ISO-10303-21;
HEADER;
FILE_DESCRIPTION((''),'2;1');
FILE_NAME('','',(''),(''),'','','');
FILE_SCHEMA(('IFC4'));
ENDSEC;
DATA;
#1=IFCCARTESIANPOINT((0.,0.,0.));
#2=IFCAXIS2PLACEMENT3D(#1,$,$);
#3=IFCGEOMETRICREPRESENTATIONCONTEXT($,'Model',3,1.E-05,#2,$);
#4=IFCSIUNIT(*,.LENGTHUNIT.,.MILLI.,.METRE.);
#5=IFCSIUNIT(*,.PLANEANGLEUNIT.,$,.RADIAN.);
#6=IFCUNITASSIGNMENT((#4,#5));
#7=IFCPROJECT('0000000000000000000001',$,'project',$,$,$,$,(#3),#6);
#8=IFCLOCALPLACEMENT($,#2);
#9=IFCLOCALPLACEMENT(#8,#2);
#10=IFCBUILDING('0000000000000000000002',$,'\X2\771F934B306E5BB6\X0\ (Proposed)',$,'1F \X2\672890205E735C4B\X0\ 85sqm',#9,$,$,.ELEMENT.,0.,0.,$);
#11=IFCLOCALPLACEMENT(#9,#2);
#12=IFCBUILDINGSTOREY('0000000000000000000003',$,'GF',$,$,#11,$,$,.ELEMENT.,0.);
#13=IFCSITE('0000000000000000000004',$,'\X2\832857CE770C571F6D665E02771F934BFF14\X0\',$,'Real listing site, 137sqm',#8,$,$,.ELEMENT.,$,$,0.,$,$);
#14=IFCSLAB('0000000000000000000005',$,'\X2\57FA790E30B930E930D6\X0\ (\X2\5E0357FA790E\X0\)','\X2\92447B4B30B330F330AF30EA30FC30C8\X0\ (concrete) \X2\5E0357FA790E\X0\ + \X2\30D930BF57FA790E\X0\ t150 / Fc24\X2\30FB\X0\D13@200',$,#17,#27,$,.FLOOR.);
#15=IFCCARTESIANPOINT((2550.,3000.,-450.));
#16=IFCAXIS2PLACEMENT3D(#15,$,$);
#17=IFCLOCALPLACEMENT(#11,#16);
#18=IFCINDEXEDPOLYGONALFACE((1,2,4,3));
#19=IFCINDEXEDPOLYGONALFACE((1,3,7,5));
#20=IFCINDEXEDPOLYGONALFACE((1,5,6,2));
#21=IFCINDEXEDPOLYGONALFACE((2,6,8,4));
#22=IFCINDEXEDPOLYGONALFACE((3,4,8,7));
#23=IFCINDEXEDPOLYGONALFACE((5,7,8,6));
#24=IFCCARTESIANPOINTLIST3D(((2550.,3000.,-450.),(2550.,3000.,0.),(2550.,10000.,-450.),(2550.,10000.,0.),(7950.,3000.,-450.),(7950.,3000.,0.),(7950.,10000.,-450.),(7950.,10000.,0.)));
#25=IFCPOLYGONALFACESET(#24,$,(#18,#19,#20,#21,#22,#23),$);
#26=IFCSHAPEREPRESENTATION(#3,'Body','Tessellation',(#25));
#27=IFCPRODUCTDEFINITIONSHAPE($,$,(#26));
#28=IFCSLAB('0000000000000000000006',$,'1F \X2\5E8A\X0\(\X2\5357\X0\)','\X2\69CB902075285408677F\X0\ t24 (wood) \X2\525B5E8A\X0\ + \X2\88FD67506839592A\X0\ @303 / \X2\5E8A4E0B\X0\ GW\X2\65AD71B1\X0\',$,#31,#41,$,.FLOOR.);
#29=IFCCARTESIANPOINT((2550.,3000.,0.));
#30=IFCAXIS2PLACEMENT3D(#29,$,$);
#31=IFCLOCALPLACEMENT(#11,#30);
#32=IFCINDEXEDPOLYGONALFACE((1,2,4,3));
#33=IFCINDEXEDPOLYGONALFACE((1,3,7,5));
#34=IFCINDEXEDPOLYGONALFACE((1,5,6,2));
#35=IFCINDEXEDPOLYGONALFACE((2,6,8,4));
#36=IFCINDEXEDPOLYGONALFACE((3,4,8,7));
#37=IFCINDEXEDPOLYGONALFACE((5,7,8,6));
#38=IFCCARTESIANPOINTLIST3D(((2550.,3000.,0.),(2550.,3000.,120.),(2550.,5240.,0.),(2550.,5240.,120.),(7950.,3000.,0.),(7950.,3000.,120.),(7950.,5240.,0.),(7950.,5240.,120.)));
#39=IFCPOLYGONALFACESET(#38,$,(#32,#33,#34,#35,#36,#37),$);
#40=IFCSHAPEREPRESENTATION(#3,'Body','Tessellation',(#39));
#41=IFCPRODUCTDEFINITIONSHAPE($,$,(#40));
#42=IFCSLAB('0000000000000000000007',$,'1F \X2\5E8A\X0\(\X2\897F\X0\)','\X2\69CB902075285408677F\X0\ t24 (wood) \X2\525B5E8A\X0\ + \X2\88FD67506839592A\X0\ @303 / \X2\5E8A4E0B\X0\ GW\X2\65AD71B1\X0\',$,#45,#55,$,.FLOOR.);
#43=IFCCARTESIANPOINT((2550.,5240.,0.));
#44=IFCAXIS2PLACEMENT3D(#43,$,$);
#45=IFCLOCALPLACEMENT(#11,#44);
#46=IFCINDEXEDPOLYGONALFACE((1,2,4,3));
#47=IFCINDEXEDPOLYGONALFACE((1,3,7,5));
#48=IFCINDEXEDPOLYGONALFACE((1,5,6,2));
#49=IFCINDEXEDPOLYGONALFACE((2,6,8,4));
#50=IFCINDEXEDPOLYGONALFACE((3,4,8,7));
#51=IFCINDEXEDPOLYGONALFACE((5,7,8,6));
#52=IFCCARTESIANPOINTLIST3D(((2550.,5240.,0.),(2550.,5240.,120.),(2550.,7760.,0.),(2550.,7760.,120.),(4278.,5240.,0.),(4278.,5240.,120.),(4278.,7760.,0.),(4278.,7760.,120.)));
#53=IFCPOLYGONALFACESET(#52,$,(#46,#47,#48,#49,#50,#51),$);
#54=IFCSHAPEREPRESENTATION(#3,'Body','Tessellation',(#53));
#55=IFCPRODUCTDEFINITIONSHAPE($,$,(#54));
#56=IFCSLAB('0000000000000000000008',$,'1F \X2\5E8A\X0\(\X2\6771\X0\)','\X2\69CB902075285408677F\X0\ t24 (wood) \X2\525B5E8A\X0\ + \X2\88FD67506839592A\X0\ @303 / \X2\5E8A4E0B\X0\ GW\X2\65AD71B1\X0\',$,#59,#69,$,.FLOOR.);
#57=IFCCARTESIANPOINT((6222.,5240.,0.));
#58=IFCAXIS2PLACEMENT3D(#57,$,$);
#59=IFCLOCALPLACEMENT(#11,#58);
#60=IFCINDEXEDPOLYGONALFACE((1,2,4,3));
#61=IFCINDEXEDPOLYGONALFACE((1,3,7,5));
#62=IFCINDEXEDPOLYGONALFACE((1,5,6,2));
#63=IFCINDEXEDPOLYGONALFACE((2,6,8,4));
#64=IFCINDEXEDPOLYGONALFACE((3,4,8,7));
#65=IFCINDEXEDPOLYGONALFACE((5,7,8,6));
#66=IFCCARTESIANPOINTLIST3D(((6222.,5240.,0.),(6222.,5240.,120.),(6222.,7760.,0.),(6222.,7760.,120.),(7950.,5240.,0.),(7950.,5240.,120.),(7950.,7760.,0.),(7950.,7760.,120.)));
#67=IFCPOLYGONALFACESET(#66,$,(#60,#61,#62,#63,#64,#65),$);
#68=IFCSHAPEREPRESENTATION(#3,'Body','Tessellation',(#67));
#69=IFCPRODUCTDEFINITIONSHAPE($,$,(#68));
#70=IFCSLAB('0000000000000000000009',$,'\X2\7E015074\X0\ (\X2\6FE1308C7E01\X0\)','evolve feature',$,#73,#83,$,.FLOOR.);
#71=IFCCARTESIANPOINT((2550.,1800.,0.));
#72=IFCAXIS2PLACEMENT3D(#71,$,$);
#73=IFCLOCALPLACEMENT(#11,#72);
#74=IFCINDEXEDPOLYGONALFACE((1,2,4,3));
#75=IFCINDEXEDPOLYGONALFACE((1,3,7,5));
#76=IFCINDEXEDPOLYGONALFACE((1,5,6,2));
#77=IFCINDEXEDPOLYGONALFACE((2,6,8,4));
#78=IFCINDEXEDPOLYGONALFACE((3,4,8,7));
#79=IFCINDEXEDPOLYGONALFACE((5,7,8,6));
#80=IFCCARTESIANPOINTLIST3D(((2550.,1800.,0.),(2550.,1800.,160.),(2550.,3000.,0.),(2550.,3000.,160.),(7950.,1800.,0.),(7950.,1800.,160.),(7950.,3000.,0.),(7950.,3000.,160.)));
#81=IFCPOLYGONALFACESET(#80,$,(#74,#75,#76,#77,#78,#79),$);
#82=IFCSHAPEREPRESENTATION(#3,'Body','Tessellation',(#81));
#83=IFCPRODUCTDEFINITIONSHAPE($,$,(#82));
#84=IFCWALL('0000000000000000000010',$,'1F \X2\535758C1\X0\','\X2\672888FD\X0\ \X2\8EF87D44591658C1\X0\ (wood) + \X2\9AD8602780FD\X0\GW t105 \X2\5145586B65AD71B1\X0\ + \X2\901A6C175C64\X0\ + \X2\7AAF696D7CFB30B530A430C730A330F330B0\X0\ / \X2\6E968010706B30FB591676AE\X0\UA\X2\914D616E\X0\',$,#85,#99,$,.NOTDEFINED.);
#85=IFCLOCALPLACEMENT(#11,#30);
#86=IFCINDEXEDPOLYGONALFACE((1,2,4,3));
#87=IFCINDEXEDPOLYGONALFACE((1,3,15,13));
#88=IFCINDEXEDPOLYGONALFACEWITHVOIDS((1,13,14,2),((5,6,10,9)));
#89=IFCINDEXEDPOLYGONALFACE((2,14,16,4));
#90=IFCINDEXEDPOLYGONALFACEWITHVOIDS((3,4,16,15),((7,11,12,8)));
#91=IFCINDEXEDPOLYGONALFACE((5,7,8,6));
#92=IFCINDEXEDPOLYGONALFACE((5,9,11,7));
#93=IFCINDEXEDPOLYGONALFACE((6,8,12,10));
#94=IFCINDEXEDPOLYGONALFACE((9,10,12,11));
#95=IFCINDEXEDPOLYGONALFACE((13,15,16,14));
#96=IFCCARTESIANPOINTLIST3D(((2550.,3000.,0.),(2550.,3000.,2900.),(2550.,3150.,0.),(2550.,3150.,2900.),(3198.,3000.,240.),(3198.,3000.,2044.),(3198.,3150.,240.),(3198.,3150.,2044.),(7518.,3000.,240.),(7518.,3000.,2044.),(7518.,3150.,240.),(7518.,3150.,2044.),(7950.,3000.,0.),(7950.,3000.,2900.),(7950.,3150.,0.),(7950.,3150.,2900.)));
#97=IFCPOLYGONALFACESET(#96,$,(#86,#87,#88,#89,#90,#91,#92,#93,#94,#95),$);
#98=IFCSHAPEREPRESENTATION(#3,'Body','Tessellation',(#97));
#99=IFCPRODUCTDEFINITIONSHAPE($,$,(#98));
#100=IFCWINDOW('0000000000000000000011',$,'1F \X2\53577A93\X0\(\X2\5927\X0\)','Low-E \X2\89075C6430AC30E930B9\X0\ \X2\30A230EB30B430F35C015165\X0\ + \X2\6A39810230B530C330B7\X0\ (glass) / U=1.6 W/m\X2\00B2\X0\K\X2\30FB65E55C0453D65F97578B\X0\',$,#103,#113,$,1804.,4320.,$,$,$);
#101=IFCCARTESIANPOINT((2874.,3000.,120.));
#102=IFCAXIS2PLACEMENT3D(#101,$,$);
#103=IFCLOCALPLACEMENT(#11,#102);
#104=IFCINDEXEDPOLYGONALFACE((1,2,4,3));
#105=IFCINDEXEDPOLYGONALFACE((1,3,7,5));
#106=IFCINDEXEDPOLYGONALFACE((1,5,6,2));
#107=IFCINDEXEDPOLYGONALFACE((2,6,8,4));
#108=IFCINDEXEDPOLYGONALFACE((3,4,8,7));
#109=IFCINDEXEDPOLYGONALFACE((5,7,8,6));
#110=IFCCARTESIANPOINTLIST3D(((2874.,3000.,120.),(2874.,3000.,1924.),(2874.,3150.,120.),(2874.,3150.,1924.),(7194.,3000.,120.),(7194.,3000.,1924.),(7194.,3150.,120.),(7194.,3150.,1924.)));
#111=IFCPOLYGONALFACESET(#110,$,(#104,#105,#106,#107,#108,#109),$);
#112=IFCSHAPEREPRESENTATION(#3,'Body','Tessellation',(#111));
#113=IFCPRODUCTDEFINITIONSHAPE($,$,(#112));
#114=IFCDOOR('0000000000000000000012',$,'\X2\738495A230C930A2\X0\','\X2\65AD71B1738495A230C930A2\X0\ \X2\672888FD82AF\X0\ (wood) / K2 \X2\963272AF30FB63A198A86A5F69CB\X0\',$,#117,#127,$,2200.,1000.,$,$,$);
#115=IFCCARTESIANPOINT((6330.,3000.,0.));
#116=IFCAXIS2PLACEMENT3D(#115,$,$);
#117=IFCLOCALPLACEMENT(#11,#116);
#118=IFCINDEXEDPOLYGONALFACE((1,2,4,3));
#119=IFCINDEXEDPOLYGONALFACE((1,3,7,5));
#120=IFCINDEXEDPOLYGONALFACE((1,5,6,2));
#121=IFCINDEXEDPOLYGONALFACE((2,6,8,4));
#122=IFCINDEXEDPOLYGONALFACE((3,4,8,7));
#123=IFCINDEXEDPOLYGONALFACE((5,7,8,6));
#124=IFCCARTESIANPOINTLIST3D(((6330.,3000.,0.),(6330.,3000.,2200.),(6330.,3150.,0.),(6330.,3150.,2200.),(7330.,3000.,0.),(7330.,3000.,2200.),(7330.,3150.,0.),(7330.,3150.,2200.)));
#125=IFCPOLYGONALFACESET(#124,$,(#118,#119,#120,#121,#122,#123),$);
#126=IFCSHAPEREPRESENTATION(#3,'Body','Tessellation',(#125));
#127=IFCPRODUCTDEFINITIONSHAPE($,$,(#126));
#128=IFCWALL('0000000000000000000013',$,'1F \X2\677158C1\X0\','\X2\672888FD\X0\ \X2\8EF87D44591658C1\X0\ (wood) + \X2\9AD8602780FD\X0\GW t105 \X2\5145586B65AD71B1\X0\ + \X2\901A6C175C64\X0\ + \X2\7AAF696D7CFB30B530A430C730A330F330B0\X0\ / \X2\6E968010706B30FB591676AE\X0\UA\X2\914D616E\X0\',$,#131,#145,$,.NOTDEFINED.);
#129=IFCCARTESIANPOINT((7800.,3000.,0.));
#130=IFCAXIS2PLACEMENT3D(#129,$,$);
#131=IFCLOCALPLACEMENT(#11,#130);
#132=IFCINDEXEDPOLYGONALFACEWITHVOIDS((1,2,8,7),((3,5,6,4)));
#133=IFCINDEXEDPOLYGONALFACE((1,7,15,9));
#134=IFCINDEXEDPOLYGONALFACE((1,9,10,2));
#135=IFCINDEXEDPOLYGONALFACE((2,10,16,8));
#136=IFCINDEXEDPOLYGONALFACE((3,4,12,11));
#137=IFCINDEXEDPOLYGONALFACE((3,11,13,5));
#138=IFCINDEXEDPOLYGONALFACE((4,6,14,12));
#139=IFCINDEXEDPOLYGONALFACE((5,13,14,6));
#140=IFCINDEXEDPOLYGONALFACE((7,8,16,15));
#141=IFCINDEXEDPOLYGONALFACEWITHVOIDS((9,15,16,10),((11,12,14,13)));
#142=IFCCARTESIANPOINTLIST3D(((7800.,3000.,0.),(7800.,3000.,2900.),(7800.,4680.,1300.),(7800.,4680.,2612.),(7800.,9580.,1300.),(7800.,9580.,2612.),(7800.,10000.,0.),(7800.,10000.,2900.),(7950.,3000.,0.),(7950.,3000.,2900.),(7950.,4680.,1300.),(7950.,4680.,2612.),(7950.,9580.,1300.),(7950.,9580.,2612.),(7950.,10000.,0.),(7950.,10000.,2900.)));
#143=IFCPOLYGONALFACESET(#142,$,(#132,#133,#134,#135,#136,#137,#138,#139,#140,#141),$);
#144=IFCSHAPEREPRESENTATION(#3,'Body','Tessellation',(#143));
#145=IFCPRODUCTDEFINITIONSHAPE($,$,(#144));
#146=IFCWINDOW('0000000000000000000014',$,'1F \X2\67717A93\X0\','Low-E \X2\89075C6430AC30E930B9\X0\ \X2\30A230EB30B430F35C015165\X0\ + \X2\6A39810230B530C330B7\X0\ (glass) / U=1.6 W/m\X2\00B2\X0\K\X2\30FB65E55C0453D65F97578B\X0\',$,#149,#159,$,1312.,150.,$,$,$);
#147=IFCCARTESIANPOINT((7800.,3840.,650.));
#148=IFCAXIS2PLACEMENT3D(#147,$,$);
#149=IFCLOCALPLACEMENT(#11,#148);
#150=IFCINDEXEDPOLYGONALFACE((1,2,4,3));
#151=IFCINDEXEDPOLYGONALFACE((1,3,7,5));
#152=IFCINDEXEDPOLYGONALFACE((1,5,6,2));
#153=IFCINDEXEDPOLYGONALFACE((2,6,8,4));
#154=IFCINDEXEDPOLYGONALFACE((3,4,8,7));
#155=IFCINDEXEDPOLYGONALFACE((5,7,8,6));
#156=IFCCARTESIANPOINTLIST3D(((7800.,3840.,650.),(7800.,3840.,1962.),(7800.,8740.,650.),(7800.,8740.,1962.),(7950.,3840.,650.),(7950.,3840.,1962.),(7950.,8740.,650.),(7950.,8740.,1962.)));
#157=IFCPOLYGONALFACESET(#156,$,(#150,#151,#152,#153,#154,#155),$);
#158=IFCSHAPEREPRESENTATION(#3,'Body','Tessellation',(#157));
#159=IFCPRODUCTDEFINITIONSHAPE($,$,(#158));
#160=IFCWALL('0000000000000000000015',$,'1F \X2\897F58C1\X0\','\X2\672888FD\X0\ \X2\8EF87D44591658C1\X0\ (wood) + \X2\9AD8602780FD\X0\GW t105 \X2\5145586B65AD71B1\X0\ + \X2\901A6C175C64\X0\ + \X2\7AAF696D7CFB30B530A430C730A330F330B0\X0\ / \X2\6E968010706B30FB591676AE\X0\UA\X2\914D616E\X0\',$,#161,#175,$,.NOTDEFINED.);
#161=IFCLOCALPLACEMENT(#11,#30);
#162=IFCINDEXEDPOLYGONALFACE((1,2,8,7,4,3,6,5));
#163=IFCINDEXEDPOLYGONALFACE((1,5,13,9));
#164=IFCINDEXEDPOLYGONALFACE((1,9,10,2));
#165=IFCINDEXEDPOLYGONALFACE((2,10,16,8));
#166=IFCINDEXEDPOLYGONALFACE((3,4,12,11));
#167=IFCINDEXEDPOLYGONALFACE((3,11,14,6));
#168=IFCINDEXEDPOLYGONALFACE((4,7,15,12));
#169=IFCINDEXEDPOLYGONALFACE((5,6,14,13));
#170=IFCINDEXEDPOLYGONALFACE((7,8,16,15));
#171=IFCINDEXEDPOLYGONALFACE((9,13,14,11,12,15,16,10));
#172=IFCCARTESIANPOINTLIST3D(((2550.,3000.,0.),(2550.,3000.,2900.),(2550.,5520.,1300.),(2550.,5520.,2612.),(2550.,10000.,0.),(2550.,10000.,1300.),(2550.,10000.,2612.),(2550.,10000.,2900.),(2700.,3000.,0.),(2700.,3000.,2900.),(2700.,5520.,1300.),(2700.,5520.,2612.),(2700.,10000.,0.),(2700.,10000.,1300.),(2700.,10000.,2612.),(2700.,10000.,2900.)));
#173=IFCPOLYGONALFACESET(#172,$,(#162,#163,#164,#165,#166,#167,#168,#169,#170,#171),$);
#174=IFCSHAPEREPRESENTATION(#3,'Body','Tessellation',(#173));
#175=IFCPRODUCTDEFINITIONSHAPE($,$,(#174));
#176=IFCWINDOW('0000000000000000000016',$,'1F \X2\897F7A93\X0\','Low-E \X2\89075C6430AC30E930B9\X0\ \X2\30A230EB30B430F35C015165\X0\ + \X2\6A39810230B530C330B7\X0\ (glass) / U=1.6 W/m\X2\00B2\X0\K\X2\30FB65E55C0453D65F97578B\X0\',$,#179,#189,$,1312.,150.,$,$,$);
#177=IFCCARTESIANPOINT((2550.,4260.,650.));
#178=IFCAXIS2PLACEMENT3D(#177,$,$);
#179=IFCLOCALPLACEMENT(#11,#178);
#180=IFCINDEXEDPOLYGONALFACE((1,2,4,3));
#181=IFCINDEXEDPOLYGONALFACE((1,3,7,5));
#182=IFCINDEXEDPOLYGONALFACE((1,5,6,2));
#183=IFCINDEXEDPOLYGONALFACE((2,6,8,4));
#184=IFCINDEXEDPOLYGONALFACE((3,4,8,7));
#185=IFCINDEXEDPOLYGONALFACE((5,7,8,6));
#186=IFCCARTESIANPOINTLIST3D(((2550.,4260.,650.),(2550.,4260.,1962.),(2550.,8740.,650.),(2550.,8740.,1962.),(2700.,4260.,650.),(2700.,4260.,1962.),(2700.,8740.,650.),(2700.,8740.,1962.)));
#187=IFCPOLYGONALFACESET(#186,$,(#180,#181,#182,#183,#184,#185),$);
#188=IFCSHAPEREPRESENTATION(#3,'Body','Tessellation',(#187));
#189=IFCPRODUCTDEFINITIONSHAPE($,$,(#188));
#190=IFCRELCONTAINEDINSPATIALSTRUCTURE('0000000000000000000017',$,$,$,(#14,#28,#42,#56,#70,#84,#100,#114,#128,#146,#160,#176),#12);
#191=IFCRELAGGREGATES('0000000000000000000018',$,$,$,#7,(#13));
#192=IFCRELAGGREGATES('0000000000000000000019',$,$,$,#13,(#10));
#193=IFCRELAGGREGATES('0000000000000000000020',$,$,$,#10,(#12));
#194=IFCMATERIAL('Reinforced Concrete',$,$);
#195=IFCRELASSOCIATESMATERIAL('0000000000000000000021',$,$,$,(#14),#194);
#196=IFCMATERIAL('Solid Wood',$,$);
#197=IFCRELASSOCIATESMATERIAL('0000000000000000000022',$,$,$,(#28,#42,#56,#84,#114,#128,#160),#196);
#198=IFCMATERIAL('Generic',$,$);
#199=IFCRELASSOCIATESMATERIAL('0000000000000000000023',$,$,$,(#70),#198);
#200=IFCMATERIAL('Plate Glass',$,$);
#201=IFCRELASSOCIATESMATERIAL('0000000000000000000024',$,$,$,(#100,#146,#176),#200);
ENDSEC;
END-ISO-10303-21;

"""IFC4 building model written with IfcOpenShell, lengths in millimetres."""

from ifc_helpers import new_model, si_unit, frame, frame_2d, origin, place, context, project, spatial, rectangle, extrude, material, element, fill, save


model = new_model("IFC4")

# Units and contexts
model_context = context("Model", 3, precision=1e-05, world=origin())
ifc_project = project(units=[si_unit("LENGTHUNIT", "METRE", prefix="MILLI"), si_unit("PLANEANGLEUNIT", "RADIAN")], contexts=[model_context])

# Site, building, storey
site_placement = place(None, origin())
site = spatial("IfcSite", under=ifc_project, at=site_placement, Name="茨城県土浦市真鍋４", ObjectType="Real listing site, 137sqm", CompositionType="ELEMENT", RefElevation=0.0)
building_placement = place(site_placement, origin())
building = spatial("IfcBuilding", under=site, at=building_placement, Name="真鍋の家 (Proposed)", ObjectType="1F 木造平屋 85sqm", CompositionType="ELEMENT", ElevationOfRefHeight=0.0, ElevationOfTerrain=0.0)
storey_placement = place(building_placement, origin())
storey = spatial("IfcBuildingStorey", under=building, at=storey_placement, Name="GF", CompositionType="ELEMENT", Elevation=0.0)

# Slabs
ifc_material_1 = material(Name="Reinforced Concrete")
slab_1_placement = place(storey_placement, frame((2550.0, 3000.0, -450.0)))
element("IfcSlab", 1, at=slab_1_placement, inside=storey, material=ifc_material_1, Name="基礎スラブ (布基礎)", Description="鉄筋コンクリート (concrete) 布基礎 + ベタ基礎 t150 / Fc24・D13@200", PredefinedType="FLOOR", context=model_context, shape_type="SweptSolid", body=[
    extrude(rectangle(XDim=5400.0, YDim=7000.0, at=frame_2d((2700.0, 3500.0))), frame((2550.0, 3000.0, -450.0)), (0.0, 0.0, 1.0), 450.0),
])
ifc_material_2 = material(Name="Solid Wood")
slab_2_placement = place(storey_placement, frame((2550.0, 3000.0, 0.0)))
element("IfcSlab", 2, at=slab_2_placement, inside=storey, material=ifc_material_2, Name="1F 床(南)", Description="構造用合板 t24 (wood) 剛床 + 製材根太 @303 / 床下 GW断熱", PredefinedType="FLOOR", context=model_context, shape_type="SweptSolid", body=[
    extrude(rectangle(XDim=5400.0, YDim=2240.0, at=frame_2d((2700.0, 1120.0))), frame((2550.0, 3000.0, 0.0)), (0.0, 0.0, 1.0), 120.0),
])
slab_3_placement = place(storey_placement, frame((2550.0, 5240.0, 0.0)))
element("IfcSlab", 3, at=slab_3_placement, inside=storey, material=ifc_material_2, Name="1F 床(西)", Description="構造用合板 t24 (wood) 剛床 + 製材根太 @303 / 床下 GW断熱", PredefinedType="FLOOR", context=model_context, shape_type="SweptSolid", body=[
    extrude(rectangle(XDim=1728.0, YDim=2520.0, at=frame_2d((864.0, 1260.0))), frame((2550.0, 5240.0, 0.0)), (0.0, 0.0, 1.0), 120.0),
])
slab_4_placement = place(storey_placement, frame((6222.0, 5240.0, 0.0)))
element("IfcSlab", 4, at=slab_4_placement, inside=storey, material=ifc_material_2, Name="1F 床(東)", Description="構造用合板 t24 (wood) 剛床 + 製材根太 @303 / 床下 GW断熱", PredefinedType="FLOOR", context=model_context, shape_type="SweptSolid", body=[
    extrude(rectangle(XDim=1728.0, YDim=2520.0, at=frame_2d((864.0, 1260.0))), frame((6222.0, 5240.0, 0.0)), (0.0, 0.0, 1.0), 120.0),
])
ifc_material_3 = material(Name="Generic")
slab_5_placement = place(storey_placement, frame((2550.0, 1800.0, 0.0)))
element("IfcSlab", 5, at=slab_5_placement, inside=storey, material=ifc_material_3, Name="縁側 (濡れ縁)", Description="evolve feature", PredefinedType="FLOOR", context=model_context, shape_type="SweptSolid", body=[
    extrude(rectangle(XDim=5400.0, YDim=1200.0, at=frame_2d((2700.0, 600.0))), frame((2550.0, 1800.0, 0.0)), (0.0, 0.0, 1.0), 160.0),
])

# Wall, openings, window, door
wall_1_placement = place(storey_placement, frame((2550.0, 3000.0, 0.0)))
wall_1 = element("IfcWall", 6, at=wall_1_placement, inside=storey, material=ifc_material_2, Name="1F 南壁", Description="木製 軸組外壁 (wood) + 高性能GW t105 充填断熱 + 通気層 + 窯業系サイディング / 準耐火・外皮UA配慮", PredefinedType="NOTDEFINED", context=model_context, shape_type="SweptSolid", body=[
    extrude(rectangle(XDim=5400.0, YDim=150.0, at=frame_2d((2700.0, 75.0))), frame((2550.0, 3000.0, 0.0)), (0.0, 0.0, 1.0), 2900.0),
])
opening_1_placement = place(storey_placement, frame((2874.0, 3000.0, 120.0)))
opening_1 = element("IfcOpeningElement", 7, at=opening_1_placement, cuts=wall_1, PredefinedType="NOTDEFINED", context=model_context, shape_type="SweptSolid", body=[
    extrude(rectangle(XDim=4320.0, YDim=150.0, at=frame_2d((2160.0, 75.0))), frame((2874.0, 3000.0, 120.0)), (0.0, 0.0, 1.0), 1804.0),
])
opening_2_placement = place(storey_placement, frame((6330.0, 3000.0, 0.0)))
opening_2 = element("IfcOpeningElement", 8, at=opening_2_placement, cuts=wall_1, PredefinedType="NOTDEFINED", context=model_context, shape_type="SweptSolid", body=[
    extrude(rectangle(XDim=1000.0, YDim=150.0, at=frame_2d((500.0, 75.0))), frame((6330.0, 3000.0, 0.0)), (0.0, 0.0, 1.0), 2200.0),
])
ifc_material_4 = material(Name="Plate Glass")
window_1_placement = place(storey_placement, frame((2874.0, 3000.0, 120.0)))
window_1 = element("IfcWindow", 9, at=window_1_placement, inside=storey, material=ifc_material_4, Name="1F 南窓(大)", Description="Low-E 複層ガラス アルゴン封入 + 樹脂サッシ (glass) / U=1.6 W/m²K・日射取得型", OverallHeight=1804.0, OverallWidth=4320.0, context=model_context, shape_type="SweptSolid", body=[
    extrude(rectangle(XDim=4320.0, YDim=150.0, at=frame_2d((2160.0, 75.0))), frame((2874.0, 3000.0, 120.0)), (0.0, 0.0, 1.0), 1804.0),
])
fill(opening_1, window_1)
door_placement = place(storey_placement, frame((6330.0, 3000.0, 0.0)))
door = element("IfcDoor", 10, at=door_placement, inside=storey, material=ifc_material_2, Name="玄関ドア", Description="断熱玄関ドア 木製芯 (wood) / K2 防犯・採風機構", OverallHeight=2200.0, OverallWidth=1000.0, context=model_context, shape_type="SweptSolid", body=[
    extrude(rectangle(XDim=1000.0, YDim=150.0, at=frame_2d((500.0, 75.0))), frame((6330.0, 3000.0, 0.0)), (0.0, 0.0, 1.0), 2200.0),
])
fill(opening_2, door)

# Walls, openings, windows
wall_2_placement = place(storey_placement, frame((7800.0, 3000.0, 0.0)))
wall_2 = element("IfcWall", 11, at=wall_2_placement, inside=storey, material=ifc_material_2, Name="1F 東壁", Description="木製 軸組外壁 (wood) + 高性能GW t105 充填断熱 + 通気層 + 窯業系サイディング / 準耐火・外皮UA配慮", PredefinedType="NOTDEFINED", context=model_context, shape_type="SweptSolid", body=[
    extrude(rectangle(XDim=150.0, YDim=7000.0, at=frame_2d((75.0, 3500.0))), frame((7800.0, 3000.0, 0.0)), (0.0, 0.0, 1.0), 2900.0),
])
opening_3_placement = place(storey_placement, frame((7800.0, 3840.0, 650.0)))
opening_3 = element("IfcOpeningElement", 12, at=opening_3_placement, cuts=wall_2, PredefinedType="NOTDEFINED", context=model_context, shape_type="SweptSolid", body=[
    extrude(rectangle(XDim=150.0, YDim=4900.0, at=frame_2d((75.0, 2450.0))), frame((7800.0, 3840.0, 650.0)), (0.0, 0.0, 1.0), 1312.0),
])
window_2_placement = place(storey_placement, frame((7800.0, 3840.0, 650.0)))
window_2 = element("IfcWindow", 13, at=window_2_placement, inside=storey, material=ifc_material_4, Name="1F 東窓", Description="Low-E 複層ガラス アルゴン封入 + 樹脂サッシ (glass) / U=1.6 W/m²K・日射取得型", OverallHeight=1312.0, OverallWidth=150.0, context=model_context, shape_type="SweptSolid", body=[
    extrude(rectangle(XDim=150.0, YDim=4900.0, at=frame_2d((75.0, 2450.0))), frame((7800.0, 3840.0, 650.0)), (0.0, 0.0, 1.0), 1312.0),
])
fill(opening_3, window_2)
wall_3_placement = place(storey_placement, frame((2550.0, 3000.0, 0.0)))
wall_3 = element("IfcWall", 14, at=wall_3_placement, inside=storey, material=ifc_material_2, Name="1F 西壁", Description="木製 軸組外壁 (wood) + 高性能GW t105 充填断熱 + 通気層 + 窯業系サイディング / 準耐火・外皮UA配慮", PredefinedType="NOTDEFINED", context=model_context, shape_type="SweptSolid", body=[
    extrude(rectangle(XDim=150.0, YDim=7000.0, at=frame_2d((75.0, 3500.0))), frame((2550.0, 3000.0, 0.0)), (0.0, 0.0, 1.0), 2900.0),
])
opening_4_placement = place(storey_placement, frame((2550.0, 4260.0, 650.0)))
opening_4 = element("IfcOpeningElement", 15, at=opening_4_placement, cuts=wall_3, PredefinedType="NOTDEFINED", context=model_context, shape_type="SweptSolid", body=[
    extrude(rectangle(XDim=150.0, YDim=4480.0, at=frame_2d((75.0, 2240.0))), frame((2550.0, 4260.0, 650.0)), (0.0, 0.0, 1.0), 1312.0),
])
window_3_placement = place(storey_placement, frame((2550.0, 4260.0, 650.0)))
window_3 = element("IfcWindow", 16, at=window_3_placement, inside=storey, material=ifc_material_4, Name="1F 西窓", Description="Low-E 複層ガラス アルゴン封入 + 樹脂サッシ (glass) / U=1.6 W/m²K・日射取得型", OverallHeight=1312.0, OverallWidth=150.0, context=model_context, shape_type="SweptSolid", body=[
    extrude(rectangle(XDim=150.0, YDim=4480.0, at=frame_2d((75.0, 2240.0))), frame((2550.0, 4260.0, 650.0)), (0.0, 0.0, 1.0), 1312.0),
])
fill(opening_4, window_3)

save(model, "model.ifc")
